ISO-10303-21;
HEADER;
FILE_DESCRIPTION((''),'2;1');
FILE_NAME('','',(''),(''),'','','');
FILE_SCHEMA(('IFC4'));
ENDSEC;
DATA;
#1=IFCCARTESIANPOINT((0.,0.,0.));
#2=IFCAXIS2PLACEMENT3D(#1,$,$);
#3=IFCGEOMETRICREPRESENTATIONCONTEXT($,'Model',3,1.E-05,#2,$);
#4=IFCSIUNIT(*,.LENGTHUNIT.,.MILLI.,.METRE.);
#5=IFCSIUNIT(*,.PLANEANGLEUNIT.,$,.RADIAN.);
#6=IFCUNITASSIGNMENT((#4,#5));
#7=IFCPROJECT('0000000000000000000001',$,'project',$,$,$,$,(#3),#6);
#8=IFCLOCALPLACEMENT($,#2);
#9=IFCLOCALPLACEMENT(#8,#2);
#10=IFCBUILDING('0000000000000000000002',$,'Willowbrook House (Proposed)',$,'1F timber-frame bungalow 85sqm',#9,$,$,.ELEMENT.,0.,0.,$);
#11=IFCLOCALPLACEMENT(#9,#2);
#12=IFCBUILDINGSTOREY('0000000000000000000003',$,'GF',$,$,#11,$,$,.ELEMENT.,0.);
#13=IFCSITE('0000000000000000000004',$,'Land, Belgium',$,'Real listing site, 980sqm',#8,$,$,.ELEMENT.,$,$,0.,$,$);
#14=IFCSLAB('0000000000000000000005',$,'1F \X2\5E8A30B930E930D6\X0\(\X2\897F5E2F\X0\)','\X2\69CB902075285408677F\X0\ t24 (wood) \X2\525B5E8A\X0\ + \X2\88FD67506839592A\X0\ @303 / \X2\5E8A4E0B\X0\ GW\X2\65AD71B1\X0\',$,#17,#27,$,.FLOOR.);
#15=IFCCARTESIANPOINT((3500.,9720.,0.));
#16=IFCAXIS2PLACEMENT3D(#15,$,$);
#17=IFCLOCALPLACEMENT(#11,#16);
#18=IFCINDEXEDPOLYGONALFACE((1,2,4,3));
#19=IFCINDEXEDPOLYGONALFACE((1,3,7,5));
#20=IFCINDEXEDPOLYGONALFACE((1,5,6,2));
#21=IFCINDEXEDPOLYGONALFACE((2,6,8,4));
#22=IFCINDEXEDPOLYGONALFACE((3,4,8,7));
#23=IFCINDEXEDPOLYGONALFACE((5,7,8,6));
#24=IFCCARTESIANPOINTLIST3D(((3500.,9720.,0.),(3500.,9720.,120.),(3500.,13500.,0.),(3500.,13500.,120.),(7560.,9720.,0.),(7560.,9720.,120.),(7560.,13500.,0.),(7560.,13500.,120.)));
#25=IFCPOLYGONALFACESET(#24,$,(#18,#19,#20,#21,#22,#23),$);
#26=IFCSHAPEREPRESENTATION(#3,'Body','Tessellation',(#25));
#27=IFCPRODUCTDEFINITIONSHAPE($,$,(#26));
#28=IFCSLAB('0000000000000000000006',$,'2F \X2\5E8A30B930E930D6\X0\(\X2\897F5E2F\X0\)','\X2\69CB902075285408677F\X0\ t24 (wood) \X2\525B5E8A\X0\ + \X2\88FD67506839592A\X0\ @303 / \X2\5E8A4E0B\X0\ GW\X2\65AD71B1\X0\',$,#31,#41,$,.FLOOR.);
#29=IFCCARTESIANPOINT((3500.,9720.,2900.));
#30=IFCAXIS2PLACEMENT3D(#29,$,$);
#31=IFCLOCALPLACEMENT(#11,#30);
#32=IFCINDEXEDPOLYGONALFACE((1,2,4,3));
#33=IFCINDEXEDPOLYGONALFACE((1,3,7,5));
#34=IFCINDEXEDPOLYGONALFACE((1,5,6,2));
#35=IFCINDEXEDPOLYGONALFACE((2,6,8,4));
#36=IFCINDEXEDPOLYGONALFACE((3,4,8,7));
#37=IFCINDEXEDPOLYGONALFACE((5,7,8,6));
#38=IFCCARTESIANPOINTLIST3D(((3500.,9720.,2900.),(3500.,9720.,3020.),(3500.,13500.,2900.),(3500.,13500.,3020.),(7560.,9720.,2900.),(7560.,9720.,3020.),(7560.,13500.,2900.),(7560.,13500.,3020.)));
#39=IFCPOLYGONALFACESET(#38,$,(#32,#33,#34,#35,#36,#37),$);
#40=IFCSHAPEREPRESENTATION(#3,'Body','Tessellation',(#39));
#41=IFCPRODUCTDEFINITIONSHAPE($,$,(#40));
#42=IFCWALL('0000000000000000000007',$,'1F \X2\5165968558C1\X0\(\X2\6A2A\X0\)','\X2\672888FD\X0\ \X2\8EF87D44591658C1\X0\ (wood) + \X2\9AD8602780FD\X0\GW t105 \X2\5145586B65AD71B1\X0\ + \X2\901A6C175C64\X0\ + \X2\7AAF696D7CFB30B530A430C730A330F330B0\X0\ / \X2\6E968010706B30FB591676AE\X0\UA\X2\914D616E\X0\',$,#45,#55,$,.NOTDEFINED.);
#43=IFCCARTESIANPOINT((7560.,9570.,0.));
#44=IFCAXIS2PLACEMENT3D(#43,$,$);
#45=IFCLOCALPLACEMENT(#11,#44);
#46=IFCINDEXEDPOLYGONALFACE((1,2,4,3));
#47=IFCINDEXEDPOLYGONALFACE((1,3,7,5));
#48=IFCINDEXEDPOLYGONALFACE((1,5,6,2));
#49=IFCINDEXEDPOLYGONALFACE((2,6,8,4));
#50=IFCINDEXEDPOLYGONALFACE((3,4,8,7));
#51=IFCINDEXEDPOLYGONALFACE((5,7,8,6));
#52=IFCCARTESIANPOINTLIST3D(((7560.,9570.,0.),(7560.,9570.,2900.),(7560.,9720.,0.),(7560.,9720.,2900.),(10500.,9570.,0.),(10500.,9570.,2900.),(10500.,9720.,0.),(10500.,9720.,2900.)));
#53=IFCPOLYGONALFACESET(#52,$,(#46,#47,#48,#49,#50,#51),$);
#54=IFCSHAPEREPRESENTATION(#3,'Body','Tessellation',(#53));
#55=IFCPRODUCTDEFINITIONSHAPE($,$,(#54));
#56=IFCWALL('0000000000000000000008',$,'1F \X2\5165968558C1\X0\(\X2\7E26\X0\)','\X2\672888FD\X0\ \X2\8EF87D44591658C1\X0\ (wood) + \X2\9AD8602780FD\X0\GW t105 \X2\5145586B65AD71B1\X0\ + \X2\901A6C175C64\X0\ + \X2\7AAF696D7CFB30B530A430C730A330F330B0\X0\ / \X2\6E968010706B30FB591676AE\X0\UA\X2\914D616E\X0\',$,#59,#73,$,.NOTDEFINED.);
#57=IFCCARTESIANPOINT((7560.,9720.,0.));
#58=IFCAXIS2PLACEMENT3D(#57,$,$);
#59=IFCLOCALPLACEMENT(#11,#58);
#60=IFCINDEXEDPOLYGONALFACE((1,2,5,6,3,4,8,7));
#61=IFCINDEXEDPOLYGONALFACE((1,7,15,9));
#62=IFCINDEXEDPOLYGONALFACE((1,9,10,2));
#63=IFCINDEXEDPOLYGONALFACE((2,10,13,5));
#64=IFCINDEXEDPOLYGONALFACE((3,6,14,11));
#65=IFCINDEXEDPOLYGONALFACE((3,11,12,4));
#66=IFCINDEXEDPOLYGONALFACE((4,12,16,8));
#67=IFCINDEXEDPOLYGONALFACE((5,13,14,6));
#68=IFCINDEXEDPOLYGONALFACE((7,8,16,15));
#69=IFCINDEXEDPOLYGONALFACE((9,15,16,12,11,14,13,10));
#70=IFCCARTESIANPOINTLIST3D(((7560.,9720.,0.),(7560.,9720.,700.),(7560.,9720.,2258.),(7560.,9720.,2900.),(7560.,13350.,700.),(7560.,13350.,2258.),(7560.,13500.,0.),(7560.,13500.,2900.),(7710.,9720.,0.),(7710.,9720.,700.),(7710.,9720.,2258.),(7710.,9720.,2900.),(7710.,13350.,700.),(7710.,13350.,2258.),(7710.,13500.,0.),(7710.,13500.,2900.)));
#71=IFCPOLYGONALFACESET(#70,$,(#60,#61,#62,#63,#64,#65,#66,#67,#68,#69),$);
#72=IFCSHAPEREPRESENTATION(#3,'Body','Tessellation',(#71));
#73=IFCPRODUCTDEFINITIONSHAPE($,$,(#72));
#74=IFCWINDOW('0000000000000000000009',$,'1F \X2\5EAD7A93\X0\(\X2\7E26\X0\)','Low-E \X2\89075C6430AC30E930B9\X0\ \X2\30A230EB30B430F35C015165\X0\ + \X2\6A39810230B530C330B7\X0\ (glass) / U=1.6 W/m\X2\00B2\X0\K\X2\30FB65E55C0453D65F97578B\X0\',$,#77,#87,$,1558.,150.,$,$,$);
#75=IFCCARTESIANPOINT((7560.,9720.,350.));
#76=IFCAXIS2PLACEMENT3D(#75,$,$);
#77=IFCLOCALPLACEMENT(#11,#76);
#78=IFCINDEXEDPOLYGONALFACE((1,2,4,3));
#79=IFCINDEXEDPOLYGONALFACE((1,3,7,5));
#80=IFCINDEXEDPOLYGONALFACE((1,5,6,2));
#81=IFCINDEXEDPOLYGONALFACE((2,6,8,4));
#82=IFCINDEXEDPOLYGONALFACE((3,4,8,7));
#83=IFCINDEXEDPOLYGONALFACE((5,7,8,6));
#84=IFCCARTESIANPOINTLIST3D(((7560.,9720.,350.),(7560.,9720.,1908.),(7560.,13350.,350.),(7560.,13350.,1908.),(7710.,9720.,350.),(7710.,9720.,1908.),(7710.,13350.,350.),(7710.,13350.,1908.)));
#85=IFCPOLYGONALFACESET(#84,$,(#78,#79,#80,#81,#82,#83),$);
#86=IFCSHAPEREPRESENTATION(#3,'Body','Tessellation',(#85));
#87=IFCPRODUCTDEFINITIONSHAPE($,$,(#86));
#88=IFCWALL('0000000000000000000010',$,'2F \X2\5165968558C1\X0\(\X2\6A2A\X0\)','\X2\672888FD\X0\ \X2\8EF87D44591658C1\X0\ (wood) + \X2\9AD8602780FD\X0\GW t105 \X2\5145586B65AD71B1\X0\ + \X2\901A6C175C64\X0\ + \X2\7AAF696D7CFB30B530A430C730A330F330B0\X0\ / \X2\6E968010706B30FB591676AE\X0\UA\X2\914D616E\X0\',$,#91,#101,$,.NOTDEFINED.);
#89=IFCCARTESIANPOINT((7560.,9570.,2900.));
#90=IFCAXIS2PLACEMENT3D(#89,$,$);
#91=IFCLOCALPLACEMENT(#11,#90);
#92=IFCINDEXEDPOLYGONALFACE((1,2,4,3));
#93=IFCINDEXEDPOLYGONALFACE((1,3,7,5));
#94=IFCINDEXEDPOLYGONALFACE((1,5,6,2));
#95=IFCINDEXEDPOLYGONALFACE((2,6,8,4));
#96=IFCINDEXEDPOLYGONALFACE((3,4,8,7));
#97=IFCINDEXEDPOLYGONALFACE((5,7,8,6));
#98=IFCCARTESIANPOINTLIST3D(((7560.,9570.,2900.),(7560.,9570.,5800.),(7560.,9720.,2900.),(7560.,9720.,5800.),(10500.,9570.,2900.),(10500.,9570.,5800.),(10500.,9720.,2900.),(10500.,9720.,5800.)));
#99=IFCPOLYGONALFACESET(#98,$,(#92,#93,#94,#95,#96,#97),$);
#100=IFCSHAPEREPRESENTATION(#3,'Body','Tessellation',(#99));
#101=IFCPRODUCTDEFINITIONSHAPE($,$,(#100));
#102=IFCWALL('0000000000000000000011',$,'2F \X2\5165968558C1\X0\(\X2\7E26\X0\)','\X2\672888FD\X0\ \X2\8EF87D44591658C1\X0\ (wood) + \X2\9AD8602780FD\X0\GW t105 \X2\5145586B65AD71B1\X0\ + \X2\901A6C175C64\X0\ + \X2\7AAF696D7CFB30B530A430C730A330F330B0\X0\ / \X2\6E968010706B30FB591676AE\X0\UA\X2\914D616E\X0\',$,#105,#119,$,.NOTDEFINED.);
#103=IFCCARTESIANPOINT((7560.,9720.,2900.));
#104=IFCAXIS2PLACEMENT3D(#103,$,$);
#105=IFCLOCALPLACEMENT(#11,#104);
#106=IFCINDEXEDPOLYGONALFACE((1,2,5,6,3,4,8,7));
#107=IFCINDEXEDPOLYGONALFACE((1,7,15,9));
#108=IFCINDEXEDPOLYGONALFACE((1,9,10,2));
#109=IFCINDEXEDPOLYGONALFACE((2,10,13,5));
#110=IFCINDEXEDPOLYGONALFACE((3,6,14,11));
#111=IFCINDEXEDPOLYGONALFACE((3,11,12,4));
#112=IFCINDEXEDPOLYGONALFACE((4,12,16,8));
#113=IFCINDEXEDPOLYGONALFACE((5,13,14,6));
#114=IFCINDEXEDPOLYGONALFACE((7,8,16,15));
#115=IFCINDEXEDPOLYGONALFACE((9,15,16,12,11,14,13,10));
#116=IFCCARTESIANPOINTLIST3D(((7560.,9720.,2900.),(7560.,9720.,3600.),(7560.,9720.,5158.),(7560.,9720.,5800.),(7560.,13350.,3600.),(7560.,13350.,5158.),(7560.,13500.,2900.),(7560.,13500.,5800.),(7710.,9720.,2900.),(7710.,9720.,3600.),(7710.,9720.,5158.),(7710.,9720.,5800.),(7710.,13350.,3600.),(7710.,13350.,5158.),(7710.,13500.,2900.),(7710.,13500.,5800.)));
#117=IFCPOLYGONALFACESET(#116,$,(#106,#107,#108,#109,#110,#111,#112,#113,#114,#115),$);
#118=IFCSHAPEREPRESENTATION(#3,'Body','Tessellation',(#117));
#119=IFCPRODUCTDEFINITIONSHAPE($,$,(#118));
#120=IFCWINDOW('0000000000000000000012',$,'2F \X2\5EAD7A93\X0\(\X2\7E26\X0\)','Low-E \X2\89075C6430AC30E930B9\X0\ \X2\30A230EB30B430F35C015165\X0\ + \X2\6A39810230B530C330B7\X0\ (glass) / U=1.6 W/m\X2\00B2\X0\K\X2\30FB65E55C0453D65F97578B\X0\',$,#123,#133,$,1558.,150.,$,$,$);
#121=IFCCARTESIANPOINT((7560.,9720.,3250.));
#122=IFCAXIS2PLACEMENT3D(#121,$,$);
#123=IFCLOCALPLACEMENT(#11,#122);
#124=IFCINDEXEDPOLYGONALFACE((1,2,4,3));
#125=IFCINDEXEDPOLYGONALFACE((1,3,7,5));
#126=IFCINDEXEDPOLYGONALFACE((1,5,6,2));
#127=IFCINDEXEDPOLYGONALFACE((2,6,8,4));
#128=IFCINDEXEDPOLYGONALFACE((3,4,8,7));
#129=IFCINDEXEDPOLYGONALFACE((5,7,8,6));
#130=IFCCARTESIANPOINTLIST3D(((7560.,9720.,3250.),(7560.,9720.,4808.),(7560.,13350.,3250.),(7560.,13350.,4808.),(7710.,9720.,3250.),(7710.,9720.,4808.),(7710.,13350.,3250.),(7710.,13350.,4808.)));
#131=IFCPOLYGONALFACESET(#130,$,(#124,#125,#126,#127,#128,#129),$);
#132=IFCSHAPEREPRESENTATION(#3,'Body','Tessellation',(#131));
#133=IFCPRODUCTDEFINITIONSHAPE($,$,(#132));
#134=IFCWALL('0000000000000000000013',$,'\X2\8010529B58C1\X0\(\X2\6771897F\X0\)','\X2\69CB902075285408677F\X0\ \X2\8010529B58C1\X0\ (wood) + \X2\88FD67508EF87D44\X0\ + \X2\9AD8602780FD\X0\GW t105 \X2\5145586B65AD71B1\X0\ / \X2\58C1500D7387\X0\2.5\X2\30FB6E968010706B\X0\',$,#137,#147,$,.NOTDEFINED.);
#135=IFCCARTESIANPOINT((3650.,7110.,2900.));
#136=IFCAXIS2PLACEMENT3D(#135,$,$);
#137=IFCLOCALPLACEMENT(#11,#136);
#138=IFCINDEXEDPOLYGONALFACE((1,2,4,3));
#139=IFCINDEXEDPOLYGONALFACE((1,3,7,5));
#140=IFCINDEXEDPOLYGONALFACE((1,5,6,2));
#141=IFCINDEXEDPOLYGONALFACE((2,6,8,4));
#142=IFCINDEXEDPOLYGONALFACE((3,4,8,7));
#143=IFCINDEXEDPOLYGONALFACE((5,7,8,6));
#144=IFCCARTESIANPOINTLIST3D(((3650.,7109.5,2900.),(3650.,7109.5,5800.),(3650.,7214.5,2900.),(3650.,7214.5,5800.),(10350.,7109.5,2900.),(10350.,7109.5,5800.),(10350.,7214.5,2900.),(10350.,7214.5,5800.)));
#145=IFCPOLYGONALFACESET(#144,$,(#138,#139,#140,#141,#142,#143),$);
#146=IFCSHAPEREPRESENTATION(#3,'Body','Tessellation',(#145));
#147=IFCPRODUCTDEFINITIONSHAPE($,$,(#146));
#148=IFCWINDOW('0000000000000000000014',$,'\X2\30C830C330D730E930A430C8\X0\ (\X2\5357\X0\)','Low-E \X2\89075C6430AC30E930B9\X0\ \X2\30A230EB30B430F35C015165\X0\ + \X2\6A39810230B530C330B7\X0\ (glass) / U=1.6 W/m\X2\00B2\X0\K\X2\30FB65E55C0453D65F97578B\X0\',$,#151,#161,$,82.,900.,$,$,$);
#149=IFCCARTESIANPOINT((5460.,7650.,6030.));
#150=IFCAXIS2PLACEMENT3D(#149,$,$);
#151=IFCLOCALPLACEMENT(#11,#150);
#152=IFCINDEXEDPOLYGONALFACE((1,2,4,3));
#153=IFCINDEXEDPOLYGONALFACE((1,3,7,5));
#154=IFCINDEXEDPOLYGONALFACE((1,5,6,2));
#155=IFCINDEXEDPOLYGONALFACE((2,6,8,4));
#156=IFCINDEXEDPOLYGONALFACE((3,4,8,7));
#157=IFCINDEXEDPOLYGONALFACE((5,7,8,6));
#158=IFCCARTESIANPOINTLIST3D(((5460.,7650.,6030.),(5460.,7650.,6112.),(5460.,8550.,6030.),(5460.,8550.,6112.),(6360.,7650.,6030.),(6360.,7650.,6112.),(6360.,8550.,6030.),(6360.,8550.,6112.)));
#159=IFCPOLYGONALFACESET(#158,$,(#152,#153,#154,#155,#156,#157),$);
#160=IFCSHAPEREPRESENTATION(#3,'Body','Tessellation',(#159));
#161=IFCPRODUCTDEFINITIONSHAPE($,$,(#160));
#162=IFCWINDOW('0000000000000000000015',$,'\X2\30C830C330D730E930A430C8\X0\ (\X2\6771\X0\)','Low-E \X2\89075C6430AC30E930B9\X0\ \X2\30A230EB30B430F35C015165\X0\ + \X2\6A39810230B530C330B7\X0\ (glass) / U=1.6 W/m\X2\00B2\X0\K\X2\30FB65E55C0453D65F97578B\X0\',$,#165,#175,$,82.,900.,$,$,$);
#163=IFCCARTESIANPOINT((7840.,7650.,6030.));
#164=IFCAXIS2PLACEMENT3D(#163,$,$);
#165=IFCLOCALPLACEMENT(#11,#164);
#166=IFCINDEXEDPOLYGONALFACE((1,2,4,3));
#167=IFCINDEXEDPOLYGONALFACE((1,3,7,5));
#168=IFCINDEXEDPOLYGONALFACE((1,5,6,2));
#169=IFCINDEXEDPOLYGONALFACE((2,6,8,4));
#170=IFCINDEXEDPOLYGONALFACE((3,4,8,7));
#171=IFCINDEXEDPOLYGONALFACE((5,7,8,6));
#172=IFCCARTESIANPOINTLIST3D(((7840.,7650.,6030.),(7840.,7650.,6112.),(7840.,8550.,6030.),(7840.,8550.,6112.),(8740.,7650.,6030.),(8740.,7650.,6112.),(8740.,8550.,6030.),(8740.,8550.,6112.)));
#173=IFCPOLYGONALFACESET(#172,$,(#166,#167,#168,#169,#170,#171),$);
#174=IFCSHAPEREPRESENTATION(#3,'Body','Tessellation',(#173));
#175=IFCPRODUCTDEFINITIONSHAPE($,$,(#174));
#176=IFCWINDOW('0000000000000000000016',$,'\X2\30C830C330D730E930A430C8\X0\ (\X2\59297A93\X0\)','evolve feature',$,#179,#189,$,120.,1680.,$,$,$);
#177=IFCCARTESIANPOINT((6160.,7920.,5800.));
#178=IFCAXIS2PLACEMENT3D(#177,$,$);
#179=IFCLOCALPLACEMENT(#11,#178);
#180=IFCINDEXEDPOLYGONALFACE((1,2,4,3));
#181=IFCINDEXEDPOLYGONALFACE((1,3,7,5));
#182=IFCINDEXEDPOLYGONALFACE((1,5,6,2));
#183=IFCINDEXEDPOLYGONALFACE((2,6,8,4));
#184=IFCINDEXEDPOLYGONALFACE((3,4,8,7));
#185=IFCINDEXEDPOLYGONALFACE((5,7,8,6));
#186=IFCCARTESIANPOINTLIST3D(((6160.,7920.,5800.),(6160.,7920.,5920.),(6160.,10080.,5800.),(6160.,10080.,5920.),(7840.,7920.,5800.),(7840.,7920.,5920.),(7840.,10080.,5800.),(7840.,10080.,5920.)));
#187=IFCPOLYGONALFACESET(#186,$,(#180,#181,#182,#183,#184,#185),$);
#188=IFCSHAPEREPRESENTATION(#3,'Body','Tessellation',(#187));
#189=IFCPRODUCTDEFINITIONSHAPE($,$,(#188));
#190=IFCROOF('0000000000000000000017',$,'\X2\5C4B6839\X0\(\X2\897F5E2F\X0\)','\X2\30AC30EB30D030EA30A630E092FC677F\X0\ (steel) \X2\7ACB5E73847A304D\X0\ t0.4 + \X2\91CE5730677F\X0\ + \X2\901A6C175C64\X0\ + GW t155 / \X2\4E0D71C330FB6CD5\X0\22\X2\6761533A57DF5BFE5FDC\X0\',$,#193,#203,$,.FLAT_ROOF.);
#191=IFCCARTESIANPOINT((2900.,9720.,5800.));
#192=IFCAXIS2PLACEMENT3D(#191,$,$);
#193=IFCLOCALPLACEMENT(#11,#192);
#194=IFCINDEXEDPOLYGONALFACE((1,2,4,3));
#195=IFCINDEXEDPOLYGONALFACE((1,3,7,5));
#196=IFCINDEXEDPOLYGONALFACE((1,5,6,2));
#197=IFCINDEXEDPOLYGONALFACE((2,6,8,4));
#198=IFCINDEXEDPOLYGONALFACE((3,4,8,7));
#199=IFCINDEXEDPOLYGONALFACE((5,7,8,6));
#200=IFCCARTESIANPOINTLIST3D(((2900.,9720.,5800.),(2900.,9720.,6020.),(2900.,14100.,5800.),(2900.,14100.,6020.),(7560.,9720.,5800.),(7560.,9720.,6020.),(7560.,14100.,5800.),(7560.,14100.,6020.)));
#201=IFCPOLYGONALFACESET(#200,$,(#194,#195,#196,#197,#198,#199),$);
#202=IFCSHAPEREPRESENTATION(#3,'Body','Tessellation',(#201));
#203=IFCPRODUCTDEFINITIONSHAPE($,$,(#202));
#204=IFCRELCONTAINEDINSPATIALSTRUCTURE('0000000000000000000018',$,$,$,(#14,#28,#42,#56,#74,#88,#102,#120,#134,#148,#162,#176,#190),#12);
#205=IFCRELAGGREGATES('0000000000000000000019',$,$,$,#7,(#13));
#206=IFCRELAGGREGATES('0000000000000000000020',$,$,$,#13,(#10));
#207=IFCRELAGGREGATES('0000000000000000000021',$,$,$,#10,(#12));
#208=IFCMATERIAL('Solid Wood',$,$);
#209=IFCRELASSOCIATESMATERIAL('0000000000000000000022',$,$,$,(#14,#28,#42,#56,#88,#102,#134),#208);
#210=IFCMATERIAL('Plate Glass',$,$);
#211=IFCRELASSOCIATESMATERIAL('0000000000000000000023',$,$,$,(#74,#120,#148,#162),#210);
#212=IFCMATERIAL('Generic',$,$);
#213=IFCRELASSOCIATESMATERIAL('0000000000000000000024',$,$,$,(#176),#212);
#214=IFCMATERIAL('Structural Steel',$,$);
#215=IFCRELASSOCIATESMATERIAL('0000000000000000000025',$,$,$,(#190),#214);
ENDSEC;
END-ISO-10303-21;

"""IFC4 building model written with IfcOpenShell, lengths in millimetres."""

from ifc_helpers import new_model, si_unit, frame, frame_2d, origin, place, context, project, spatial, rectangle, extrude, material, element, fill, save


model = new_model("IFC4")

# Units and contexts
model_context = context("Model", 3, precision=1e-05, world=origin())
ifc_project = project(units=[si_unit("LENGTHUNIT", "METRE", prefix="MILLI"), si_unit("PLANEANGLEUNIT", "RADIAN")], contexts=[model_context])

# Site, building, storey
site_placement = place(None, origin())
site = spatial("IfcSite", under=ifc_project, at=site_placement, Name="Land, Belgium", ObjectType="Real listing site, 980sqm", CompositionType="ELEMENT", RefElevation=0.0)
building_placement = place(site_placement, origin())
building = spatial("IfcBuilding", under=site, at=building_placement, Name="Willowbrook House (Proposed)", ObjectType="1F timber-frame bungalow 85sqm", CompositionType="ELEMENT", ElevationOfRefHeight=0.0, ElevationOfTerrain=0.0)
storey_placement = place(building_placement, origin())
storey = spatial("IfcBuildingStorey", under=building, at=storey_placement, Name="GF", CompositionType="ELEMENT", Elevation=0.0)

# Slabs
ifc_material_1 = material(Name="Solid Wood")
slab_1_placement = place(storey_placement, frame((3500.0, 9720.0, 0.0)))
element("IfcSlab", 1, at=slab_1_placement, inside=storey, material=ifc_material_1, Name="1F 床スラブ(西帯)", Description="構造用合板 t24 (wood) 剛床 + 製材根太 @303 / 床下 GW断熱", PredefinedType="FLOOR", context=model_context, shape_type="SweptSolid", body=[
    extrude(rectangle(XDim=4060.0, YDim=3780.0, at=frame_2d((2030.0, 1890.0))), frame((3500.0, 9720.0, 0.0)), (0.0, 0.0, 1.0), 120.0),
])
slab_2_placement = place(storey_placement, frame((3500.0, 9720.0, 2900.0)))
element("IfcSlab", 2, at=slab_2_placement, inside=storey, material=ifc_material_1, Name="2F 床スラブ(西帯)", Description="構造用合板 t24 (wood) 剛床 + 製材根太 @303 / 床下 GW断熱", PredefinedType="FLOOR", context=model_context, shape_type="SweptSolid", body=[
    extrude(rectangle(XDim=4060.0, YDim=3780.0, at=frame_2d((2030.0, 1890.0))), frame((3500.0, 9720.0, 2900.0)), (0.0, 0.0, 1.0), 120.0),
])

# Wall
wall_1_placement = place(storey_placement, frame((7560.0, 9570.0, 0.0)))
element("IfcWall", 3, at=wall_1_placement, inside=storey, material=ifc_material_1, Name="1F 入隅壁(横)", Description="木製 軸組外壁 (wood) + 高性能GW t105 充填断熱 + 通気層 + 窯業系サイディング / 準耐火・外皮UA配慮", PredefinedType="NOTDEFINED", context=model_context, shape_type="SweptSolid", body=[
    extrude(rectangle(XDim=2940.0, YDim=150.0, at=frame_2d((1470.0, 75.0))), frame((7560.0, 9570.0, 0.0)), (0.0, 0.0, 1.0), 2900.0),
])

# Wall, opening, window
wall_2_placement = place(storey_placement, frame((7560.0, 9720.0, 0.0)))
wall_2 = element("IfcWall", 4, at=wall_2_placement, inside=storey, material=ifc_material_1, Name="1F 入隅壁(縦)", Description="木製 軸組外壁 (wood) + 高性能GW t105 充填断熱 + 通気層 + 窯業系サイディング / 準耐火・外皮UA配慮", PredefinedType="NOTDEFINED", context=model_context, shape_type="SweptSolid", body=[
    extrude(rectangle(XDim=150.0, YDim=3780.0, at=frame_2d((75.0, 1890.0))), frame((7560.0, 9720.0, 0.0)), (0.0, 0.0, 1.0), 2900.0),
])
opening_1_placement = place(storey_placement, frame((7560.0, 9720.0, 350.0)))
opening_1 = element("IfcOpeningElement", 5, at=opening_1_placement, cuts=wall_2, PredefinedType="NOTDEFINED", context=model_context, shape_type="SweptSolid", body=[
    extrude(rectangle(XDim=150.0, YDim=3630.0, at=frame_2d((75.0, 1815.0))), frame((7560.0, 9720.0, 350.0)), (0.0, 0.0, 1.0), 1558.0),
])
ifc_material_2 = material(Name="Plate Glass")
window_1_placement = place(storey_placement, frame((7560.0, 9720.0, 350.0)))
window_1 = element("IfcWindow", 6, at=window_1_placement, inside=storey, material=ifc_material_2, Name="1F 庭窓(縦)", Description="Low-E 複層ガラス アルゴン封入 + 樹脂サッシ (glass) / U=1.6 W/m²K・日射取得型", OverallHeight=1558.0, OverallWidth=150.0, context=model_context, shape_type="SweptSolid", body=[
    extrude(rectangle(XDim=150.0, YDim=3630.0, at=frame_2d((75.0, 1815.0))), frame((7560.0, 9720.0, 350.0)), (0.0, 0.0, 1.0), 1558.0),
])
fill(opening_1, window_1)

# Wall
wall_3_placement = place(storey_placement, frame((7560.0, 9570.0, 2900.0)))
element("IfcWall", 7, at=wall_3_placement, inside=storey, material=ifc_material_1, Name="2F 入隅壁(横)", Description="木製 軸組外壁 (wood) + 高性能GW t105 充填断熱 + 通気層 + 窯業系サイディング / 準耐火・外皮UA配慮", PredefinedType="NOTDEFINED", context=model_context, shape_type="SweptSolid", body=[
    extrude(rectangle(XDim=2940.0, YDim=150.0, at=frame_2d((1470.0, 75.0))), frame((7560.0, 9570.0, 2900.0)), (0.0, 0.0, 1.0), 2900.0),
])

# Wall, opening, window
wall_4_placement = place(storey_placement, frame((7560.0, 9720.0, 2900.0)))
wall_4 = element("IfcWall", 8, at=wall_4_placement, inside=storey, material=ifc_material_1, Name="2F 入隅壁(縦)", Description="木製 軸組外壁 (wood) + 高性能GW t105 充填断熱 + 通気層 + 窯業系サイディング / 準耐火・外皮UA配慮", PredefinedType="NOTDEFINED", context=model_context, shape_type="SweptSolid", body=[
    extrude(rectangle(XDim=150.0, YDim=3780.0, at=frame_2d((75.0, 1890.0))), frame((7560.0, 9720.0, 2900.0)), (0.0, 0.0, 1.0), 2900.0),
])
opening_2_placement = place(storey_placement, frame((7560.0, 9720.0, 3250.0)))
opening_2 = element("IfcOpeningElement", 9, at=opening_2_placement, cuts=wall_4, PredefinedType="NOTDEFINED", context=model_context, shape_type="SweptSolid", body=[
    extrude(rectangle(XDim=150.0, YDim=3630.0, at=frame_2d((75.0, 1815.0))), frame((7560.0, 9720.0, 3250.0)), (0.0, 0.0, 1.0), 1558.0),
])
window_2_placement = place(storey_placement, frame((7560.0, 9720.0, 3250.0)))
window_2 = element("IfcWindow", 10, at=window_2_placement, inside=storey, material=ifc_material_2, Name="2F 庭窓(縦)", Description="Low-E 複層ガラス アルゴン封入 + 樹脂サッシ (glass) / U=1.6 W/m²K・日射取得型", OverallHeight=1558.0, OverallWidth=150.0, context=model_context, shape_type="SweptSolid", body=[
    extrude(rectangle(XDim=150.0, YDim=3630.0, at=frame_2d((75.0, 1815.0))), frame((7560.0, 9720.0, 3250.0)), (0.0, 0.0, 1.0), 1558.0),
])
fill(opening_2, window_2)

# Wall
wall_5_placement = place(storey_placement, frame((3650.0, 7110.0, 2900.0)))
element("IfcWall", 11, at=wall_5_placement, inside=storey, material=ifc_material_1, Name="耐力壁(東西)", Description="構造用合板 耐力壁 (wood) + 製材軸組 + 高性能GW t105 充填断熱 / 壁倍率2.5・準耐火", PredefinedType="NOTDEFINED", context=model_context, shape_type="SweptSolid", body=[
    extrude(rectangle(XDim=6700.0, YDim=105.0, at=frame_2d((3350.0, 52.0))), frame((3650.0, 7110.0, 2900.0)), (0.0, 0.0, 1.0), 2900.0),
])

# Windows
window_3_placement = place(storey_placement, frame((5460.0, 7650.0, 6030.0)))
element("IfcWindow", 12, at=window_3_placement, inside=storey, material=ifc_material_2, Name="トップライト (南)", Description="Low-E 複層ガラス アルゴン封入 + 樹脂サッシ (glass) / U=1.6 W/m²K・日射取得型", OverallHeight=82.0, OverallWidth=900.0, context=model_context, shape_type="SweptSolid", body=[
    extrude(rectangle(XDim=900.0, YDim=900.0, at=frame_2d((450.0, 450.0))), frame((5460.0, 7650.0, 6030.0)), (0.0, 0.0, 1.0), 82.0),
])
window_4_placement = place(storey_placement, frame((7840.0, 7650.0, 6030.0)))
element("IfcWindow", 13, at=window_4_placement, inside=storey, material=ifc_material_2, Name="トップライト (東)", Description="Low-E 複層ガラス アルゴン封入 + 樹脂サッシ (glass) / U=1.6 W/m²K・日射取得型", OverallHeight=82.0, OverallWidth=900.0, context=model_context, shape_type="SweptSolid", body=[
    extrude(rectangle(XDim=900.0, YDim=900.0, at=frame_2d((450.0, 450.0))), frame((7840.0, 7650.0, 6030.0)), (0.0, 0.0, 1.0), 82.0),
])
ifc_material_3 = material(Name="Generic")
window_5_placement = place(storey_placement, frame((6160.0, 7920.0, 5800.0)))
element("IfcWindow", 14, at=window_5_placement, inside=storey, material=ifc_material_3, Name="トップライト (天窓)", Description="evolve feature", OverallHeight=120.0, OverallWidth=1680.0, context=model_context, shape_type="SweptSolid", body=[
    extrude(rectangle(XDim=1680.0, YDim=2160.0, at=frame_2d((840.0, 1080.0))), frame((6160.0, 7920.0, 5800.0)), (0.0, 0.0, 1.0), 120.0),
])

# Roof
ifc_material_4 = material(Name="Structural Steel")
for number, where, name in (
    (15, (2900.0, 9720.0, 5800.0), "屋根(西帯)"),
):
    element("IfcRoof", number, at=place(storey_placement, frame(where)), inside=storey, material=ifc_material_4, Name=name, Description="ガルバリウム鋼板 (steel) 立平葺き t0.4 + 野地板 + 通気層 + GW t155 / 不燃・法22条区域対応", PredefinedType="FLAT_ROOF", context=model_context, shape_type="SweptSolid", body=[
        extrude(rectangle(XDim=4660.0, YDim=4380.0, at=frame_2d((2330.0, 2190.0))), frame((2900.0, 9720.0, 5800.0)), (0.0, 0.0, 1.0), 220.0),
    ])

save(model, "model.ifc")
